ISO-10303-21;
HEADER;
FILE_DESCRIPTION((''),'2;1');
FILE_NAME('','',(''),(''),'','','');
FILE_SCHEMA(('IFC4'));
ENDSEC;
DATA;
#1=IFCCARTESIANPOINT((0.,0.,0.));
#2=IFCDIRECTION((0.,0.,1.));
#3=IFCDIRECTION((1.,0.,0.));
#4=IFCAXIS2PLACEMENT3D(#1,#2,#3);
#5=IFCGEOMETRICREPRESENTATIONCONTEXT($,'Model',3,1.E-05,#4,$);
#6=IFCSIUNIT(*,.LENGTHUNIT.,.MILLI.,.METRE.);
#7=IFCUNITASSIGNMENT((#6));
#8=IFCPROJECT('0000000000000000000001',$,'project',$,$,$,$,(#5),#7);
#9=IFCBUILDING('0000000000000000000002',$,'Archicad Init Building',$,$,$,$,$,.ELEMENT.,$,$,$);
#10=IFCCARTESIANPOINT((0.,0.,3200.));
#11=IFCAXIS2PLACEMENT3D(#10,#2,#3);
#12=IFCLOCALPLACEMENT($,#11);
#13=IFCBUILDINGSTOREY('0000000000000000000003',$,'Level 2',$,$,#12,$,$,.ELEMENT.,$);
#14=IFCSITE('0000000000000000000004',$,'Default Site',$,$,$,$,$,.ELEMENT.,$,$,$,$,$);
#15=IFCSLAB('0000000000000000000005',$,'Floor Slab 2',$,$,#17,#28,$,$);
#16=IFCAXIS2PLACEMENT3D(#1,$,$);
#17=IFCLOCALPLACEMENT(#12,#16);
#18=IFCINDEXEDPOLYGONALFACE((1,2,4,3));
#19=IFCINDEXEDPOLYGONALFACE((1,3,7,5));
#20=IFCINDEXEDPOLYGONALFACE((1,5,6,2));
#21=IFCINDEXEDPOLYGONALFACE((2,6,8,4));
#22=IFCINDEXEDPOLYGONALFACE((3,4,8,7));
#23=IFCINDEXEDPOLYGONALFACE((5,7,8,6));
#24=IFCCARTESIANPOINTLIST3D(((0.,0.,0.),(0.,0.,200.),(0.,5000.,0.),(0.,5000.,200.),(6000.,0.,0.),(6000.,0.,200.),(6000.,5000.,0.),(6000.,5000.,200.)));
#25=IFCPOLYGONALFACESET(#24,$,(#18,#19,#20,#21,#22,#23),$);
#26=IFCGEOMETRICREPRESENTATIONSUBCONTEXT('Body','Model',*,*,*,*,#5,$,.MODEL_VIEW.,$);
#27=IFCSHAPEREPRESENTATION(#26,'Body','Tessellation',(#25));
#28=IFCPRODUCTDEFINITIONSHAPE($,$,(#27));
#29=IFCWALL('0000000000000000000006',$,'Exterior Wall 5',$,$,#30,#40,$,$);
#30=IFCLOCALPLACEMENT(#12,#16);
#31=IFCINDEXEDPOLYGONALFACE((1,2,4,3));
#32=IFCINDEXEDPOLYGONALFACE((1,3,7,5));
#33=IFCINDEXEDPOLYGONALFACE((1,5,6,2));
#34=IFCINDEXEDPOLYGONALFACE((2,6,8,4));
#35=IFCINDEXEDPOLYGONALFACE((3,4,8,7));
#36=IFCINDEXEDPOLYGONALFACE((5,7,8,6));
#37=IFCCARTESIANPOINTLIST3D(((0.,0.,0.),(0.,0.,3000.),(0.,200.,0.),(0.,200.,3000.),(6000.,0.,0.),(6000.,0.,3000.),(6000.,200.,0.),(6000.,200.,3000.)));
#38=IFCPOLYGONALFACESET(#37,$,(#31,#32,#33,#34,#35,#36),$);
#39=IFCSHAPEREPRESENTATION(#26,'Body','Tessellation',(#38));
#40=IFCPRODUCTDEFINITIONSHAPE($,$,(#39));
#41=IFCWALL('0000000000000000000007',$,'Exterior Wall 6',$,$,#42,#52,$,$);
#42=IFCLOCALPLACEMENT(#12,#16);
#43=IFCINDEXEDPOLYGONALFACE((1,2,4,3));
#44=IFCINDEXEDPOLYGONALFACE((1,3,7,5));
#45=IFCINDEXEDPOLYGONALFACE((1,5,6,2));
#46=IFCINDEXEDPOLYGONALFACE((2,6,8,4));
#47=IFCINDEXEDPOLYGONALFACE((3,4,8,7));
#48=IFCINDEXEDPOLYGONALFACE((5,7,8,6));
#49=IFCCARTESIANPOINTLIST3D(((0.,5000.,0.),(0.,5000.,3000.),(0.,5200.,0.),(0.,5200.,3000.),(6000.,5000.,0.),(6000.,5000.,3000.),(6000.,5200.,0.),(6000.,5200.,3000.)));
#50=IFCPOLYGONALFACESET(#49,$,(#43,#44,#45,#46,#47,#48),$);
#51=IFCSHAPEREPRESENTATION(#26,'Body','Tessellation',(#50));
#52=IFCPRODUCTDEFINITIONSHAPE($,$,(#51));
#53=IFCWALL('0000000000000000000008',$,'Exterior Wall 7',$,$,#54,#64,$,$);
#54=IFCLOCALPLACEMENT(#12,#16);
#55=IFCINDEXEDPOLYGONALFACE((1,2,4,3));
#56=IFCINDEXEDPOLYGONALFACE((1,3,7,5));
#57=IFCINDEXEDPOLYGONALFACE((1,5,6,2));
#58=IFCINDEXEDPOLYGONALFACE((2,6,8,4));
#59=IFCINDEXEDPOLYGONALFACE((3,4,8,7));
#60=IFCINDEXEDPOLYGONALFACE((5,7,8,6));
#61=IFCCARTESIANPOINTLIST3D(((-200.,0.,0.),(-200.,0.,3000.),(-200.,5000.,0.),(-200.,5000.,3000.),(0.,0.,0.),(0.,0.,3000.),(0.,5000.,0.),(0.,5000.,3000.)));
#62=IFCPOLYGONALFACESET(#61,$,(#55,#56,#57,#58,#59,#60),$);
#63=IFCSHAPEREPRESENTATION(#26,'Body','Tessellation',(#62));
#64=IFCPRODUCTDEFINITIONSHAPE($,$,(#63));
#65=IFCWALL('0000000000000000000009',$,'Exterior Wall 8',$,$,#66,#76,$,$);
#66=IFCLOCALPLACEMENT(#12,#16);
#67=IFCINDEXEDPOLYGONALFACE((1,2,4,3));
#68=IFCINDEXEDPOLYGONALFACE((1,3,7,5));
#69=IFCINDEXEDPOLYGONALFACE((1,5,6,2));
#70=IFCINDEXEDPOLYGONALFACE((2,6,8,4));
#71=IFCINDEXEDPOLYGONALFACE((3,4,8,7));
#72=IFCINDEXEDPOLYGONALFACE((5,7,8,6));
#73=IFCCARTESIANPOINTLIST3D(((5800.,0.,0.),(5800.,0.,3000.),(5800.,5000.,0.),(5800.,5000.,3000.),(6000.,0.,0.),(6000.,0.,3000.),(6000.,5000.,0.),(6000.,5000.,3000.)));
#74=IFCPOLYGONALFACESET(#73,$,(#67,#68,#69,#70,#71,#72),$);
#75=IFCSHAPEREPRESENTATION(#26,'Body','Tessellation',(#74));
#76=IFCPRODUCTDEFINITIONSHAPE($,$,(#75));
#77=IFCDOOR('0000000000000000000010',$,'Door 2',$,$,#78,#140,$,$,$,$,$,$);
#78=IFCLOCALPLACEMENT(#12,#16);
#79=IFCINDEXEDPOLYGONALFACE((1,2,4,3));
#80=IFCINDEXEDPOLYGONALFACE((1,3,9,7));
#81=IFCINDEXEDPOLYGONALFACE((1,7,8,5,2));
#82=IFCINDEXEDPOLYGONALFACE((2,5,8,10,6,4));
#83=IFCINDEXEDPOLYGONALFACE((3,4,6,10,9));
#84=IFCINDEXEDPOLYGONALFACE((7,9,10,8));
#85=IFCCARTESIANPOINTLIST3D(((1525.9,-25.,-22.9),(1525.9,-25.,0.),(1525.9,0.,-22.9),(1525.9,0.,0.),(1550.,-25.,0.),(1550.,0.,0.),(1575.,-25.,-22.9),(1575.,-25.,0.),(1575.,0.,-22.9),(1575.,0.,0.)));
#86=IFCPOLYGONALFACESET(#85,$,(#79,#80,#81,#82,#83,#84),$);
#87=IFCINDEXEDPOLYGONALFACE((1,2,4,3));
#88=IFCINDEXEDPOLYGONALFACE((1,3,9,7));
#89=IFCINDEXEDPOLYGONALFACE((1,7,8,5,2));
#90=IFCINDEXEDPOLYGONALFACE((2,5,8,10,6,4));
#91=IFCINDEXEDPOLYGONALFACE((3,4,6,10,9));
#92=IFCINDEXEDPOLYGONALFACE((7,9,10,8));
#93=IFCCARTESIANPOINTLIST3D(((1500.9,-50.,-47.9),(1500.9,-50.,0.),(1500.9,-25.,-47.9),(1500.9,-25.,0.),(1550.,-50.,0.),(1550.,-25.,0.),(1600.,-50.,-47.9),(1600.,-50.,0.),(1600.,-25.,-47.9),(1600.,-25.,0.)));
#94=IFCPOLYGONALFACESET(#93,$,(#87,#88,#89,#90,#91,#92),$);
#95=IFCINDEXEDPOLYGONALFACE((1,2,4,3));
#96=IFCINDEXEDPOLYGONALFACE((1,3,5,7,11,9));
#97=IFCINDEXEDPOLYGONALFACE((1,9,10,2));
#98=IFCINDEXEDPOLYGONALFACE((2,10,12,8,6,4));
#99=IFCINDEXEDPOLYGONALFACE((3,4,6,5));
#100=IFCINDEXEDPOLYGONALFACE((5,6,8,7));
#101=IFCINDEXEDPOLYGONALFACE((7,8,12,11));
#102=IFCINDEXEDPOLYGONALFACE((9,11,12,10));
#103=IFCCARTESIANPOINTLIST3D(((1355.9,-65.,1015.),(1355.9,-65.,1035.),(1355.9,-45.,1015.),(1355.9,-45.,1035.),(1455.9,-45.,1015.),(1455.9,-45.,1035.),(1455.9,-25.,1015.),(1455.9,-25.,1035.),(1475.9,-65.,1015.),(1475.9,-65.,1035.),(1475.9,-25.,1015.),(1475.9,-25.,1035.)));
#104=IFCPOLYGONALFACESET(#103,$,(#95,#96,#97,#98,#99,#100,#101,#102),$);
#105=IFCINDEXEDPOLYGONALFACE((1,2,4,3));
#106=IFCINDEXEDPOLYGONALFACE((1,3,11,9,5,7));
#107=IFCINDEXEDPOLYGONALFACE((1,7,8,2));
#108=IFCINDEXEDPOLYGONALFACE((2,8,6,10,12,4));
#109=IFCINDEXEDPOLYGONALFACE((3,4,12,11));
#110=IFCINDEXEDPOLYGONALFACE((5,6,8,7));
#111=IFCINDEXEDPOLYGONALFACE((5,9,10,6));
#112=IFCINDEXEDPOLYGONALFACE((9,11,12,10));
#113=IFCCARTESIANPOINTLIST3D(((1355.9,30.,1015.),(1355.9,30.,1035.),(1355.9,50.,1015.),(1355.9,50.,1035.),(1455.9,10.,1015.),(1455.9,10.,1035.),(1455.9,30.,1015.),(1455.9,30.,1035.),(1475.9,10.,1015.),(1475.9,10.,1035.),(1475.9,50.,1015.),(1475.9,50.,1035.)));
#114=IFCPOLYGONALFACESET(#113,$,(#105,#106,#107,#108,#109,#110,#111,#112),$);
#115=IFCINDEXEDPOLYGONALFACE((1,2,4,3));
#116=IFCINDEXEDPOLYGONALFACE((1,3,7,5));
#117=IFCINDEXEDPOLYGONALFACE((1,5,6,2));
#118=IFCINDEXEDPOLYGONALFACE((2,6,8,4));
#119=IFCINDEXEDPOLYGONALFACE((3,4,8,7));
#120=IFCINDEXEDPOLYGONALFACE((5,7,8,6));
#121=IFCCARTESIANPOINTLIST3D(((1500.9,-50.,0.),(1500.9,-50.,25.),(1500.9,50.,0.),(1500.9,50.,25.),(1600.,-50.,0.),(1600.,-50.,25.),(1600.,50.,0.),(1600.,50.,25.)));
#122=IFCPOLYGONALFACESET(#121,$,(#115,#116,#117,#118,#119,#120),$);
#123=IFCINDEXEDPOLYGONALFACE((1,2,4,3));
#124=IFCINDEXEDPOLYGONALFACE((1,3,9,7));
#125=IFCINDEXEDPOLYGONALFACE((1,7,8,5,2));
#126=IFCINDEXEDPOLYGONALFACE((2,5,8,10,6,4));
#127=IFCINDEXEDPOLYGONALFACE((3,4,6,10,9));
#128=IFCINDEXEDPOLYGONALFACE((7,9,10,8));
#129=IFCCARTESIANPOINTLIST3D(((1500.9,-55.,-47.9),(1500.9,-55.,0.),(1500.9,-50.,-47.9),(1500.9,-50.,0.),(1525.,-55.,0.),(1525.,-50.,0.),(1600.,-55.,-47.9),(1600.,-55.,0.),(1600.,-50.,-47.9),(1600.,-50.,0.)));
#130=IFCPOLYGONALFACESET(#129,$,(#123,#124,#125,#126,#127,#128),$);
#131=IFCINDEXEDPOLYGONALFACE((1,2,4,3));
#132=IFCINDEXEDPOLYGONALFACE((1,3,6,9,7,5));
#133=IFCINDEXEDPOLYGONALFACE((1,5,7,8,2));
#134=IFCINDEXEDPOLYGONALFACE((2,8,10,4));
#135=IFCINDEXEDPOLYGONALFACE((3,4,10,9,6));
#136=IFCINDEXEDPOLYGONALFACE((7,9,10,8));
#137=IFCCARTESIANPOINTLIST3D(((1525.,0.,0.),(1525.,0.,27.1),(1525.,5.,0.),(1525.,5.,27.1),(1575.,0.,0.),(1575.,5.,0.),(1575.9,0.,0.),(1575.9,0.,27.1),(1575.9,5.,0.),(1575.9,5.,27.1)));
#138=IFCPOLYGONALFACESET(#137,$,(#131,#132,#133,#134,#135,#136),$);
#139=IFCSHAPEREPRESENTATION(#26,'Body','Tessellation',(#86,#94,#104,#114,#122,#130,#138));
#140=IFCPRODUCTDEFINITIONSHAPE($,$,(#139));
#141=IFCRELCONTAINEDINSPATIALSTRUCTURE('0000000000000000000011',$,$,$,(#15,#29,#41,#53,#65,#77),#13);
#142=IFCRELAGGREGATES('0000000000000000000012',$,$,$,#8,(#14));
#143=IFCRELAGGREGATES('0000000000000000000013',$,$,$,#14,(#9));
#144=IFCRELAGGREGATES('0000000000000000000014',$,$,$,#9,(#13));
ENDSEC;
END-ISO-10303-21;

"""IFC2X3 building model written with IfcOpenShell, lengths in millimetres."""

from ifc_helpers import new_model, si_unit, frame, origin_with_axes, place, context, subcontext, project, spatial, polyline, outline, extrude, element, save


model = new_model("IFC2X3")

# Units and contexts
model_context = context("Model", 3, precision=1e-05, world=origin_with_axes())
body_context = subcontext(model_context, "Body", "Model", "MODEL_VIEW")
ifc_project = project(units=[si_unit("LENGTHUNIT", "METRE", prefix="MILLI")], contexts=[model_context])

# Site, building, storey
site = spatial("IfcSite", under=ifc_project, Name="Default Site", CompositionType="ELEMENT")
building = spatial("IfcBuilding", under=site, Name="Archicad Init Building", CompositionType="ELEMENT")
storey_placement = place(None, frame((0.0, 0.0, 3200.0), z_axis=(0.0, 0.0, 1.0), x_axis=(1.0, 0.0, 0.0)))
storey = spatial("IfcBuildingStorey", under=building, at=storey_placement, Name="Level 2", CompositionType="ELEMENT")

# Slab
slab_placement = place(storey_placement, origin_with_axes())
element("IfcSlab", 1, at=slab_placement, inside=storey, Name="Floor Slab 2", context=body_context, shape_type="SweptSolid", body=[
    extrude(outline(polyline([(0.0, 0.0), (6000.0, 0.0), (6000.0, 5000.0), (0.0, 5000.0), (0.0, 0.0)])), origin_with_axes(), (0.0, 0.0, 1.0), 200.0),
])

# Walls
for number, where, z_axis, x_axis, name in (
    (2, (0.0, 0.0, 0.0), (0.0, 0.0, 1.0), (1.0, 0.0, 0.0), "Exterior Wall 5"),
    (3, (0.0, 5000.0, 0.0), (0.0, 0.0, 1.0), (1.0, 0.0, 0.0), "Exterior Wall 6"),
):
    element("IfcWall", number, at=place(storey_placement, frame(where, z_axis=z_axis, x_axis=x_axis)), inside=storey, Name=name, context=body_context, shape_type="SweptSolid", body=[
        extrude(outline(polyline([(0.0, 0.0), (0.0, 200.0), (6000.0, 200.0), (6000.0, 0.0), (0.0, 0.0)])), origin_with_axes(), (0.0, 0.0, 1.0), 3000.0),
    ])
for number, where, z_axis, x_axis, name in (
    (4, (0.0, 0.0, 0.0), (0.0, 0.0, 1.0), (0.0, 1.0, 0.0), "Exterior Wall 7"),
    (5, (6000.0, 0.0, 0.0), (0.0, 0.0, 1.0), (0.0, 1.0, 0.0), "Exterior Wall 8"),
):
    element("IfcWall", number, at=place(storey_placement, frame(where, z_axis=z_axis, x_axis=x_axis)), inside=storey, Name=name, context=body_context, shape_type="SweptSolid", body=[
        extrude(outline(polyline([(0.0, 0.0), (0.0, 200.0), (5000.0, 200.0), (5000.0, 0.0), (0.0, 0.0)])), origin_with_axes(), (0.0, 0.0, 1.0), 3000.0),
    ])

# Door
door_placement = place(storey_placement, frame((1550.0, -50.0, 0.0), z_axis=(0.0, 0.0, 1.0), x_axis=(1.0, 0.0, 0.0)))
element("IfcDoor", 6, at=door_placement, inside=storey, Name="Door 2", context=body_context, shape_type="SweptSolid", body=[
    extrude(outline(polyline([(0.0, 0.0), (0.0, 2.1), (0.9, 2.1), (0.9, 0.0), (-24.1, 0.0), (-24.1, -22.9), (25.0, -22.9), (25.0, 0.0), (0.0, 0.0)])), frame((0.0, 25.0, 0.0), z_axis=(0.0, -1.0, 0.0), x_axis=(1.0, 0.0, 0.0)), (0.0, 0.0, -1.0), 25.0),
    extrude(outline(polyline([(0.0, 0.0), (0.0, 2.1), (0.9, 2.1), (0.9, 0.0), (-49.1, 0.0), (-49.1, -47.9), (50.0, -47.9), (50.0, 0.0), (0.0, 0.0)])), frame((0.0, 0.0, 0.0), z_axis=(0.0, -1.0, 0.0), x_axis=(1.0, 0.0, 0.0)), (0.0, 0.0, -1.0), 25.0),
    extrude(outline(polyline([(0.0, 0.0), (-49.1, 0.0), (-49.1, 35.0), (0.0, 35.0), (0.0, 0.0)])), frame((25.0, 25.0, 25.0), z_axis=(0.0, 0.0, 1.0), x_axis=(1.0, 0.0, 0.0)), (0.0, 0.0, 1.0), -47.9),
    extrude(outline(polyline([(0.0, 0.0), (0.0, -40.0), (-120.0, -40.0), (-120.0, -20.0), (-20.0, -20.0), (-20.0, 0.0), (0.0, 0.0)])), frame((-74.1, 25.0, 1015.0), z_axis=(0.0, 0.0, 1.0), x_axis=(1.0, 0.0, 0.0)), (0.0, 0.0, 1.0), 20.0),
    extrude(outline(polyline([(0.0, 0.0), (0.0, 40.0), (-120.0, 40.0), (-120.0, 20.0), (-20.0, 20.0), (-20.0, 0.0), (0.0, 0.0)])), frame((-74.1, 60.0, 1015.0), z_axis=(0.0, 0.0, 1.0), x_axis=(1.0, 0.0, 0.0)), (0.0, 0.0, 1.0), 20.0),
    extrude(outline(polyline([(0.0, 0.0), (-99.1, 0.0), (-99.1, 100.0), (0.0, 100.0), (0.0, 0.0)])), frame((50.0, 0.0, 0.0), z_axis=(0.0, 0.0, 1.0), x_axis=(1.0, 0.0, 0.0)), (0.0, 0.0, 1.0), 25.0),
    extrude(outline(polyline([(0.0, 0.0), (0.0, 27.1), (50.9, 27.1), (50.9, 0.0), (-24.1, 0.0), (-24.1, -47.9), (75.0, -47.9), (75.0, 0.0), (0.0, 0.0)])), frame((-25.0, -5.0, 0.0), z_axis=(0.0, -1.0, 0.0), x_axis=(1.0, 0.0, 0.0)), (0.0, 0.0, -1.0), 5.0),
    extrude(outline(polyline([(0.0, 0.0), (0.0, 27.1), (50.9, 27.1), (50.9, 0.0), (0.9, 0.0), (0.9, -22.9), (50.0, -22.9), (50.0, 0.0), (0.0, 0.0)])), frame((-25.0, 50.0, 0.0), z_axis=(0.0, -1.0, 0.0), x_axis=(1.0, 0.0, 0.0)), (0.0, 0.0, -1.0), 5.0),
])

save(model, "model.ifc")
